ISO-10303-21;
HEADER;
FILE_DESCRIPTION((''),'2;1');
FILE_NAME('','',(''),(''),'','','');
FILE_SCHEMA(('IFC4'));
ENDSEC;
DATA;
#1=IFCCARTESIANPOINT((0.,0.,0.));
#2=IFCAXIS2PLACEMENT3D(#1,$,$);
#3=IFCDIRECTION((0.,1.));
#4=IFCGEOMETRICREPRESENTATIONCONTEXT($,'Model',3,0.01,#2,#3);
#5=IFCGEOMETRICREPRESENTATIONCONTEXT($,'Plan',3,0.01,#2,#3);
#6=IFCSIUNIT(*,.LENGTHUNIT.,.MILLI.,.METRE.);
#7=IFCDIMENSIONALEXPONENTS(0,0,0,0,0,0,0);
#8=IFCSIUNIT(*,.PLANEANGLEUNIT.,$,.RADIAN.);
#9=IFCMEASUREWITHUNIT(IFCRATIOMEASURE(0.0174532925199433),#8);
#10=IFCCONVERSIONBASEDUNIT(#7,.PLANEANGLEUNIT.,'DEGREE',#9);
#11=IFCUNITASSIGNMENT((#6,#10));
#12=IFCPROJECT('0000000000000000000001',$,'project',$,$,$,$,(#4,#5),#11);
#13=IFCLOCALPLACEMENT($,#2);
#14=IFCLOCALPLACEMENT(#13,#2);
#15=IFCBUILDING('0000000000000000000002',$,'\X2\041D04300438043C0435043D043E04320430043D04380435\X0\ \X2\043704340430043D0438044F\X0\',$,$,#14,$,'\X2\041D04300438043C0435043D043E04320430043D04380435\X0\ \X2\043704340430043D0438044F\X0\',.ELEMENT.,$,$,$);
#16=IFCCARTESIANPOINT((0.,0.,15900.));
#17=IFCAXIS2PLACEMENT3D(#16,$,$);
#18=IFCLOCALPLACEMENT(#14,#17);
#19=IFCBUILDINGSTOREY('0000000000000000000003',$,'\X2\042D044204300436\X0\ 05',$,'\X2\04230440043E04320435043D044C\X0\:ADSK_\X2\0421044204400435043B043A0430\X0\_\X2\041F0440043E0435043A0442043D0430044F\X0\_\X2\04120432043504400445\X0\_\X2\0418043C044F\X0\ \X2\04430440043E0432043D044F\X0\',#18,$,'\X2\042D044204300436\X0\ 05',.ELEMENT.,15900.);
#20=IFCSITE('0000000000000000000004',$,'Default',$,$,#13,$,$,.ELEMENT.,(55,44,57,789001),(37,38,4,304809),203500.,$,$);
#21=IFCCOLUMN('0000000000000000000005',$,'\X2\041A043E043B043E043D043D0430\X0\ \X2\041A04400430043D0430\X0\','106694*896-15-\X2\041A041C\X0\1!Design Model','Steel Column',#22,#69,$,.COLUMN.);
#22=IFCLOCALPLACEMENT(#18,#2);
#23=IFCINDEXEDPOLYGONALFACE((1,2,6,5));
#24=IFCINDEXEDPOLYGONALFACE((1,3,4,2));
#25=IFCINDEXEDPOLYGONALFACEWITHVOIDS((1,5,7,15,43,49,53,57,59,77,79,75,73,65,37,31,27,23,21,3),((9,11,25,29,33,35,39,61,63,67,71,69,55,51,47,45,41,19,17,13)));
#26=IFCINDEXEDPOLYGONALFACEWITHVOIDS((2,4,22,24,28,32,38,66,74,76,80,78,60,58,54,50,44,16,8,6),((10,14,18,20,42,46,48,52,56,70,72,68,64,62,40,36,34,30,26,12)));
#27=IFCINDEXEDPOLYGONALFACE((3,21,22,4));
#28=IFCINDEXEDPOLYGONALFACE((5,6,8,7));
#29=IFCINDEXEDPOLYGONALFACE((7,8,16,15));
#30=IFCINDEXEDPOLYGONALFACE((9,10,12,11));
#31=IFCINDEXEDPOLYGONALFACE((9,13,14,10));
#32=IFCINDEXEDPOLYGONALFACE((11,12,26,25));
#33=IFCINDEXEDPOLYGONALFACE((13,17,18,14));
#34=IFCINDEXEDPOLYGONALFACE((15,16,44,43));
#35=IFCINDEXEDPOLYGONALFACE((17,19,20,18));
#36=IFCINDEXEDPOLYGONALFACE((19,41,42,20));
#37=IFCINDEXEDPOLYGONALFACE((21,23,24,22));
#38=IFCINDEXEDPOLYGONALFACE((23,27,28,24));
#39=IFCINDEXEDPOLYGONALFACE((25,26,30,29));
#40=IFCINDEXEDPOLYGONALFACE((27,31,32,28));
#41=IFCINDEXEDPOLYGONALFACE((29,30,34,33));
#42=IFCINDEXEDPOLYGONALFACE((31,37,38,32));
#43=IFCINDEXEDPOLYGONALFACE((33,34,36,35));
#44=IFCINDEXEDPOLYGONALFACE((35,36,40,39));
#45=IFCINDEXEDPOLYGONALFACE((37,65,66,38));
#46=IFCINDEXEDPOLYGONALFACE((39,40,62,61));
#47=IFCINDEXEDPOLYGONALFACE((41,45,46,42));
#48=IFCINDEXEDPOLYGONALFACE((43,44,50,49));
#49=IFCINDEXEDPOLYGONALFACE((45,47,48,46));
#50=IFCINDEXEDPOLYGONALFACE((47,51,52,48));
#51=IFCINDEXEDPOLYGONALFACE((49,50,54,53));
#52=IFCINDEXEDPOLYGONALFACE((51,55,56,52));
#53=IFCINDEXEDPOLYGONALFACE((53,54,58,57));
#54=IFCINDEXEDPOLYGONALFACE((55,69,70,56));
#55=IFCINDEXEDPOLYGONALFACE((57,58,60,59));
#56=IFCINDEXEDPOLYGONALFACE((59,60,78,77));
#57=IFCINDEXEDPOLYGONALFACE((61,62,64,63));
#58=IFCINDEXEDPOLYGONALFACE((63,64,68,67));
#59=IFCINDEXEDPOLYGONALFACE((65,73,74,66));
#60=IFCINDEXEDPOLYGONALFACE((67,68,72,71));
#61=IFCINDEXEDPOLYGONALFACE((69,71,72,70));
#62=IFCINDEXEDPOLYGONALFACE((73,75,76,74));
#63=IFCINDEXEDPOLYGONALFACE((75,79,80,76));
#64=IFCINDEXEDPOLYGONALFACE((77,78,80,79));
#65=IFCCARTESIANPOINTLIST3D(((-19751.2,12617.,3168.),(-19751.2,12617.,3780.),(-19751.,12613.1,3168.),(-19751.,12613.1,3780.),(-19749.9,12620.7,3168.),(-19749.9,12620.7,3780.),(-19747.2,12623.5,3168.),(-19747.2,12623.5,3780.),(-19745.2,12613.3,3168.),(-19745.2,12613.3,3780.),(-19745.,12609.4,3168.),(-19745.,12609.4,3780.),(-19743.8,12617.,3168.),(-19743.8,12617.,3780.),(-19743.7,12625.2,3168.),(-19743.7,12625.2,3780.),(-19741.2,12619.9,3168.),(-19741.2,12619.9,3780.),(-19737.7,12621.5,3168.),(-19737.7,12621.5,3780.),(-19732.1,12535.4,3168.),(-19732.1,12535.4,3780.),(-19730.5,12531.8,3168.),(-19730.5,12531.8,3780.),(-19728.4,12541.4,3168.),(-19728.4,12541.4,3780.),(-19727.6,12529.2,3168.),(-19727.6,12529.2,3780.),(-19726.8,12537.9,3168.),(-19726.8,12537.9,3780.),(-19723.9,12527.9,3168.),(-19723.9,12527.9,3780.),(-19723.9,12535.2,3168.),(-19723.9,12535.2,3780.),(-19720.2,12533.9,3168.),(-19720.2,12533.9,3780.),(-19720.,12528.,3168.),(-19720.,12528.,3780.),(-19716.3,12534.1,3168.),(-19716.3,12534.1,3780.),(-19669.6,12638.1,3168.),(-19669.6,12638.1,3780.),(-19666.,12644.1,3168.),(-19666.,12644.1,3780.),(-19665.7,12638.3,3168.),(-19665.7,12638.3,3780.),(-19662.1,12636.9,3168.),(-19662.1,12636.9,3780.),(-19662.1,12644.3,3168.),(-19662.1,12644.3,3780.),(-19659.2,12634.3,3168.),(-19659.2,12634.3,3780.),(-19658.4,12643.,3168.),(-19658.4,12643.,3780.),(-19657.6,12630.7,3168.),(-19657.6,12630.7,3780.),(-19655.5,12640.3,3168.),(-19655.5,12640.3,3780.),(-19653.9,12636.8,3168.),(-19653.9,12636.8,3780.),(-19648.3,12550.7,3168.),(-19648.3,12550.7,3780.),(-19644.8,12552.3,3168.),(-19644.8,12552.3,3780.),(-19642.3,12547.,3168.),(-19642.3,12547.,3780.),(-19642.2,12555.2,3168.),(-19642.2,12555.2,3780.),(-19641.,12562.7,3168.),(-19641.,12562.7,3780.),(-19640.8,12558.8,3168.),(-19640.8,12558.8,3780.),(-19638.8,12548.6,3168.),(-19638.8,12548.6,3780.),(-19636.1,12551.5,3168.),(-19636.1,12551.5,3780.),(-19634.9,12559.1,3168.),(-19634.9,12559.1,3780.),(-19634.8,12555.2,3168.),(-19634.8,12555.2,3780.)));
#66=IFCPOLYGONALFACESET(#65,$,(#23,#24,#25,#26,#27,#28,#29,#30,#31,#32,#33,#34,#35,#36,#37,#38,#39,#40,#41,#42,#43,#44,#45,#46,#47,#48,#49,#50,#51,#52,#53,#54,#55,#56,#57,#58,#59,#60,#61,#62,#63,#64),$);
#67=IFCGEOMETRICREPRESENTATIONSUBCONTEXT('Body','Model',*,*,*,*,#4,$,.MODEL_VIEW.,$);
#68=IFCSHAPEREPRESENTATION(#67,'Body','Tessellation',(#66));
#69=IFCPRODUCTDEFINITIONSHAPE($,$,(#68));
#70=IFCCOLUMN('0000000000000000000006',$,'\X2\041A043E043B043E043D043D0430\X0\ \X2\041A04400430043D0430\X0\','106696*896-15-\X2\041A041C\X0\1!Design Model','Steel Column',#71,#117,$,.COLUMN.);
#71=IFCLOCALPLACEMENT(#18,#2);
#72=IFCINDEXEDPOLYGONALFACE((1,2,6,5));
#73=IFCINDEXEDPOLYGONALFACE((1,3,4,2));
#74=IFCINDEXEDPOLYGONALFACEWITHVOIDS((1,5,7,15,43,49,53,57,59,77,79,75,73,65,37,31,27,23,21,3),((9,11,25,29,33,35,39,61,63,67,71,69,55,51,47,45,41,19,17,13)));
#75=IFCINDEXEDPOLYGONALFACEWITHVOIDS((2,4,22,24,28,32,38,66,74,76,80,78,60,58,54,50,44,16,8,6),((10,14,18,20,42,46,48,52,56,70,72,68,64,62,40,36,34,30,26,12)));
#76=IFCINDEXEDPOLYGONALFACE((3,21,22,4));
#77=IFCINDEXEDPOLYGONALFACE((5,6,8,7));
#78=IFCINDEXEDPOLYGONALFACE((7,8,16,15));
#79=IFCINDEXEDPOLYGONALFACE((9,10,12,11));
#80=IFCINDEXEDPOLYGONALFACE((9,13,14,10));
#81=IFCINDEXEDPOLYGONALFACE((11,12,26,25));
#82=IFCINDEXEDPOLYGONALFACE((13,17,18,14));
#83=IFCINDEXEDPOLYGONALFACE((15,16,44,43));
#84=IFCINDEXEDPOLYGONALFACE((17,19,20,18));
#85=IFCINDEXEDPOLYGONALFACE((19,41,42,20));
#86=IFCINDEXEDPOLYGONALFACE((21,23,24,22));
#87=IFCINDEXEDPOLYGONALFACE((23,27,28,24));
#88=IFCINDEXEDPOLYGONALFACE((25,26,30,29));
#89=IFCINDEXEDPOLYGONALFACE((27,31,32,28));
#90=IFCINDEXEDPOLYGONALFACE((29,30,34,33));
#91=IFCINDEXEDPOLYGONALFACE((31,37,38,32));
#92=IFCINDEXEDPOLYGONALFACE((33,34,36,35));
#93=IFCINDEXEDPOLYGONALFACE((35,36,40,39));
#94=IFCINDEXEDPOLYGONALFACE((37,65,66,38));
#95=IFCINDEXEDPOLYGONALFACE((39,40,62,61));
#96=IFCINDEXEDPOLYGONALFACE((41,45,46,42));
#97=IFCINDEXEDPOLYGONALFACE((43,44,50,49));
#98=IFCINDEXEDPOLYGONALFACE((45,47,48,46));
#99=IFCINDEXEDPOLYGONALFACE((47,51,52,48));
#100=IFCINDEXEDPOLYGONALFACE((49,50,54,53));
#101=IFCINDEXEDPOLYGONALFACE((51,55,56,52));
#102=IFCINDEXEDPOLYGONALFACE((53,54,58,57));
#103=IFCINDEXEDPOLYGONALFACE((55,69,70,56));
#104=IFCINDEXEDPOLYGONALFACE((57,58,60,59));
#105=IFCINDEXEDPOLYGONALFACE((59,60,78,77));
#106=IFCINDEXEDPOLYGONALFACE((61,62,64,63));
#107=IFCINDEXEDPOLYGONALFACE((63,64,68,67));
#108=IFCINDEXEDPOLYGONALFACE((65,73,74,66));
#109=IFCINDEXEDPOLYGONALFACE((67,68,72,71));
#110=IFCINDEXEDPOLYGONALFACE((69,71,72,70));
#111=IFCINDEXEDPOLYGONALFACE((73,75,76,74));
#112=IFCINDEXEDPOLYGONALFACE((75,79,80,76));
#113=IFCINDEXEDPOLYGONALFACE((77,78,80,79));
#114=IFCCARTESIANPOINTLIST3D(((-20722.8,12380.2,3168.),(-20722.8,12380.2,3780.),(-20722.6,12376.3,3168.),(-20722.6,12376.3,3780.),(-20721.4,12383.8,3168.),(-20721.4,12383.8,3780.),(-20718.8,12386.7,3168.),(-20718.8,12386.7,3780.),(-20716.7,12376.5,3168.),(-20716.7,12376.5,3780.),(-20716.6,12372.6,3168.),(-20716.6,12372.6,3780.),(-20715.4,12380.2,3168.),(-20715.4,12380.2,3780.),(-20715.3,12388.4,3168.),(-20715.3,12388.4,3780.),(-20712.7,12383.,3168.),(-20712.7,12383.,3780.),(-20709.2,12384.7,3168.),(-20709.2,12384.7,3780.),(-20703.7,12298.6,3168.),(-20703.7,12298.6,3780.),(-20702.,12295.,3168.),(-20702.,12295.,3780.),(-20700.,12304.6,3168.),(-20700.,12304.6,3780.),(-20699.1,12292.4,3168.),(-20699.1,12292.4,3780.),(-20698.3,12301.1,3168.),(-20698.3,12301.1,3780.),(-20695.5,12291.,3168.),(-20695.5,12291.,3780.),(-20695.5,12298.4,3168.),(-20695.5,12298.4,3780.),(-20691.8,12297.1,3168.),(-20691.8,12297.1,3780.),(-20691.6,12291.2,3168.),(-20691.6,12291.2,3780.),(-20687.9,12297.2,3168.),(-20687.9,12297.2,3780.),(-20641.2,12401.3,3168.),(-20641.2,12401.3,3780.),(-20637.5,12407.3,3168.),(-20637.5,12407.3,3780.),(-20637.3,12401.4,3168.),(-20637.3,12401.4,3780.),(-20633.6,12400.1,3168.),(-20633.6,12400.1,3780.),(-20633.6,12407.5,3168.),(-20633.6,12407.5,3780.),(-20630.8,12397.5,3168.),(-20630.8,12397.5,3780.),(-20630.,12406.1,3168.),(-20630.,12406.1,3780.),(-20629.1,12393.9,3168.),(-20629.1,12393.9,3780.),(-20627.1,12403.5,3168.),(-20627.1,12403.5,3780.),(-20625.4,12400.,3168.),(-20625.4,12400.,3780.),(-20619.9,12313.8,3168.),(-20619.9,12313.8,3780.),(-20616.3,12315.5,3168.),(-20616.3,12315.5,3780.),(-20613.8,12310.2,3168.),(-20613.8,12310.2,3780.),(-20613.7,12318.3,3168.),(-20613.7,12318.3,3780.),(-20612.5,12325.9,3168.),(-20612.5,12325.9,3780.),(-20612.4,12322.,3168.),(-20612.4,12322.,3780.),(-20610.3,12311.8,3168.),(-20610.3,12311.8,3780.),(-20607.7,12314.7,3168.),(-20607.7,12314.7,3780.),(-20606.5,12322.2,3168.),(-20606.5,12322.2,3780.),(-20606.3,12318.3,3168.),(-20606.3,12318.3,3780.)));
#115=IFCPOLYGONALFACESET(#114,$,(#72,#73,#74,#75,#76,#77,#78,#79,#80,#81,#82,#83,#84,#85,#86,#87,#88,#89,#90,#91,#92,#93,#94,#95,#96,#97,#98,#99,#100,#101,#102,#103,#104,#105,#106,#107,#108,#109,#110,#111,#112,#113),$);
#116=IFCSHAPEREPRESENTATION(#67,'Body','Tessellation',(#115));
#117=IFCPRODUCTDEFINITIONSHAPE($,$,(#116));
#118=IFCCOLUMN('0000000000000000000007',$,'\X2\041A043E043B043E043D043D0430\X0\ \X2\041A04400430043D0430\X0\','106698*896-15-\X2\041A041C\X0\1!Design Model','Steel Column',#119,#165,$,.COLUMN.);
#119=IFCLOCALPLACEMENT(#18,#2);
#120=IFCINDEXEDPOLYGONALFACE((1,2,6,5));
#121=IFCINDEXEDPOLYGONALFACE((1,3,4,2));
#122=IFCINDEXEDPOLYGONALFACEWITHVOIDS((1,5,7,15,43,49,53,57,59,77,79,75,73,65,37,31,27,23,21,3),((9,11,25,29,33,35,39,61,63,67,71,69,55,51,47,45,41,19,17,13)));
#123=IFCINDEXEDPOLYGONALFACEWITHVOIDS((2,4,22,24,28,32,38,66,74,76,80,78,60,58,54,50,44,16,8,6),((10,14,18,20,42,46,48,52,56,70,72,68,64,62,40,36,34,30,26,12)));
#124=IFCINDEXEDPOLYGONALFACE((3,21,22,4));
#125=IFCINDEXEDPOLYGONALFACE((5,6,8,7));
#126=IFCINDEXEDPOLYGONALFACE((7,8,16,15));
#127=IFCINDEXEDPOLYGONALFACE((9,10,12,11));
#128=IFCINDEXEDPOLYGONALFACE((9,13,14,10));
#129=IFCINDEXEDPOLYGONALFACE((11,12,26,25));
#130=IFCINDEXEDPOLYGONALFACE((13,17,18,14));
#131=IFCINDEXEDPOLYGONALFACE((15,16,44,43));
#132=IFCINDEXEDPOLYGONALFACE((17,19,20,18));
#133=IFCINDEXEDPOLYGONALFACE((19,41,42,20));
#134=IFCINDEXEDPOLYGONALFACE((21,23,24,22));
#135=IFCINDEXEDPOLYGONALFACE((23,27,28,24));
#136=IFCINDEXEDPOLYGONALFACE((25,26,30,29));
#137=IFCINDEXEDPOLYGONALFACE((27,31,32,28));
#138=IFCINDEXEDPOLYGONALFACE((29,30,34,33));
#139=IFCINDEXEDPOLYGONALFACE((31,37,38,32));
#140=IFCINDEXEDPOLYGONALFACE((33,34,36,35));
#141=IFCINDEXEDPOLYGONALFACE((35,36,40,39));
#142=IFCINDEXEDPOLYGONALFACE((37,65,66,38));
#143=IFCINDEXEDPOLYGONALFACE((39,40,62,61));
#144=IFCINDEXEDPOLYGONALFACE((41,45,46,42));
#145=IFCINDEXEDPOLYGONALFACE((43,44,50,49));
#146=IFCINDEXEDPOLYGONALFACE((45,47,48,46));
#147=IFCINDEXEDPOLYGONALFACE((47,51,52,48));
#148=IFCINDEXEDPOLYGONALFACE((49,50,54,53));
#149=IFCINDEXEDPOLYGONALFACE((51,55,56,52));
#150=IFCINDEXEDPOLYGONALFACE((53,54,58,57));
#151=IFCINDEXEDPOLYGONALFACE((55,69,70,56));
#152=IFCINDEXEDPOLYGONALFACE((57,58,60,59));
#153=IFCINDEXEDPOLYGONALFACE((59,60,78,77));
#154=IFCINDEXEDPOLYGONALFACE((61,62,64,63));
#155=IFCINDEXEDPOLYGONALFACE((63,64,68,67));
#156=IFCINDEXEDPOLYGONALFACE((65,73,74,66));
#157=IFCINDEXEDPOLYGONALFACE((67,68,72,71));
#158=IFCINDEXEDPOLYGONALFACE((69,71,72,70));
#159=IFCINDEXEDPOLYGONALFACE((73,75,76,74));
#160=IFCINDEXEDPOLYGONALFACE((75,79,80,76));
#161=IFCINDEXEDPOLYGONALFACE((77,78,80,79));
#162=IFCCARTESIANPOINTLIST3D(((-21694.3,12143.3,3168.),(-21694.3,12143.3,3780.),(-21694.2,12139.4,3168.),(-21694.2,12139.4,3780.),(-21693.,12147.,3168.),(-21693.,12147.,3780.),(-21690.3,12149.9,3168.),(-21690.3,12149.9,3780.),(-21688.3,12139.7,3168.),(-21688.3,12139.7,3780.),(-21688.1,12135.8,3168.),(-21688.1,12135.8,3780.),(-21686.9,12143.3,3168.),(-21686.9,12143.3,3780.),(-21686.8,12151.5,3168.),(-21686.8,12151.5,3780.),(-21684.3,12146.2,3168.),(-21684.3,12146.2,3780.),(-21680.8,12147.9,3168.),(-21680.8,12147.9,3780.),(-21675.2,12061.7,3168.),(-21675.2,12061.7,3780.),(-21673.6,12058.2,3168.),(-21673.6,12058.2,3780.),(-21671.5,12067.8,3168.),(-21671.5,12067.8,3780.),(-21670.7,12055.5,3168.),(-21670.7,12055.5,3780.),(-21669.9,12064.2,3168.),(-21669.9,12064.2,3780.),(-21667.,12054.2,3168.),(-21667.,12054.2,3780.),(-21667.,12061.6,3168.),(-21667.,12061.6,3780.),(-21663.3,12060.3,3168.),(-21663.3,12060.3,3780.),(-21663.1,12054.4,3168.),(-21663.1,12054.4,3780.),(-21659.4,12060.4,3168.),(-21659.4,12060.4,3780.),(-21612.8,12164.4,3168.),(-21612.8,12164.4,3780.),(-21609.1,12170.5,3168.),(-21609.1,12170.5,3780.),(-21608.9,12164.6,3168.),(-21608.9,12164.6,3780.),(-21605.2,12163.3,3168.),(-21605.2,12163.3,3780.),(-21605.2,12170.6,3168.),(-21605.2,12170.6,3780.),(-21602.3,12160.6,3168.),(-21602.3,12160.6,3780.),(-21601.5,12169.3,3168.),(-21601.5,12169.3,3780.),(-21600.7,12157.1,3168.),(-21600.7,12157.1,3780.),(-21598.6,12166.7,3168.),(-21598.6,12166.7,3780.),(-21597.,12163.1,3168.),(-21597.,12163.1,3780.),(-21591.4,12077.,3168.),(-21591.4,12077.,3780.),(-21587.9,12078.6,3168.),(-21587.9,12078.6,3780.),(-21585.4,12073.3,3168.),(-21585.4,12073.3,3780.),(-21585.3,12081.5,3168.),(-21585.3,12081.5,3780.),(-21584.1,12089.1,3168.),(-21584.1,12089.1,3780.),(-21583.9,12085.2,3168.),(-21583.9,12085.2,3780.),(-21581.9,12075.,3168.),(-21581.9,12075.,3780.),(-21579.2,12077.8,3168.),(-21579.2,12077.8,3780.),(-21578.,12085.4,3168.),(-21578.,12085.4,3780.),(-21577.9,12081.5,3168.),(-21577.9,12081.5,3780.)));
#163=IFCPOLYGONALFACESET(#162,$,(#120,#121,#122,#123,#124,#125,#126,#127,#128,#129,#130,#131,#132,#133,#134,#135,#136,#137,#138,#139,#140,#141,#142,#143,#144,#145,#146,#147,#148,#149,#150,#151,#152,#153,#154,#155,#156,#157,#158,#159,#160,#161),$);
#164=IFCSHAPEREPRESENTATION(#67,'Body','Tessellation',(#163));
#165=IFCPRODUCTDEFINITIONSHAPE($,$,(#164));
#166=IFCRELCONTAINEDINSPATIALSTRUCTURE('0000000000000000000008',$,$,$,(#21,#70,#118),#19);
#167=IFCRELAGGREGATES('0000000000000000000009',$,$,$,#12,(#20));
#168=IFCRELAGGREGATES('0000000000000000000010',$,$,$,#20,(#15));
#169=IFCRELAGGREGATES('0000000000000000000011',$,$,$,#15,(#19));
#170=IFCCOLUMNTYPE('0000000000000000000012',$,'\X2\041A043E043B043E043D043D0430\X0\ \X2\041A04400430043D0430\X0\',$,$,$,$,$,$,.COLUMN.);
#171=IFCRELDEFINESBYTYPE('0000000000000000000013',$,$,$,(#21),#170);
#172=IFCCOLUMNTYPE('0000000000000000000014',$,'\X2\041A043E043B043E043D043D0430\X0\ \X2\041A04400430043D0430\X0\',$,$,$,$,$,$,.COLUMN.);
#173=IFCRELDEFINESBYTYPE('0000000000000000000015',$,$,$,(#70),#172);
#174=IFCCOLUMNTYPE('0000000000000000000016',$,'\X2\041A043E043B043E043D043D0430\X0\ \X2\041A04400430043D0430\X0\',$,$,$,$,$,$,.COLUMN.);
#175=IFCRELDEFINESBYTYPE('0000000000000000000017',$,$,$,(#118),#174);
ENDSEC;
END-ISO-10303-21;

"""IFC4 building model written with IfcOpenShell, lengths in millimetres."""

from ifc_helpers import new_model, entity, si_unit, converted_unit, direction, frame, origin, place, context, subcontext, project, spatial, indexed_curve, outline, extrude, type_object, element, save


model = new_model("IFC4")

# Units and contexts
model_context = context("Model", 3, precision=0.01, world=origin(), true_north=direction((0.0, 1.0)))
plan_context = context("Plan", 3, precision=0.01, world=origin(), true_north=direction((0.0, 1.0)))
body_context = subcontext(model_context, "Body", "Model", "MODEL_VIEW")
ifc_project = project(units=[si_unit("LENGTHUNIT", "METRE", prefix="MILLI"), converted_unit("PLANEANGLEUNIT", "DEGREE", entity("IfcRatioMeasure", 0.0174532925199433), si_unit("PLANEANGLEUNIT", "RADIAN"), dimensions=[0, 0, 0, 0, 0, 0, 0])], contexts=[model_context, plan_context])

# Site, building, storey
site_placement = place(None, origin())
site = spatial("IfcSite", under=ifc_project, at=site_placement, Name="Default", CompositionType="ELEMENT", RefLatitude=(55, 44, 57, 789001), RefLongitude=(37, 38, 4, 304809), RefElevation=203500.0)
building_placement = place(site_placement, origin())
building = spatial("IfcBuilding", under=site, at=building_placement, Name="Наименование здания", LongName="Наименование здания", CompositionType="ELEMENT")
storey_placement = place(building_placement, frame((0.0, 0.0, 15900.0)))
storey = spatial("IfcBuildingStorey", under=building, at=storey_placement, Name="Этаж 05", ObjectType="Уровень:ADSK_Стрелка_Проектная_Вверх_Имя уровня", LongName="Этаж 05", CompositionType="ELEMENT", Elevation=15900.0)

# Columns
column_type_1 = type_object("IfcColumnType", Name="Колонна Крана", PredefinedType="COLUMN")
column_1_placement = place(storey_placement, origin())
element("IfcColumn", 1, at=column_1_placement, inside=storey, type_object=column_type_1, Name="Колонна Крана", Description="106694*896-15-КМ1!Design Model", ObjectType="Steel Column", PredefinedType="COLUMN", context=body_context, shape_type="SweptSolid", body=[
    extrude(outline(indexed_curve([(29.5, -56.8), (33.4, -56.8), (37.0, -55.3), (39.7, -52.6), (41.2, -49.0), (56.8, 29.5), (56.8, 33.4), (55.3, 37.0), (52.6, 39.7), (49.0, 41.2), (-29.5, 56.8), (-33.4, 56.8), (-37.0, 55.3), (-39.7, 52.6), (-41.2, 49.0), (-56.8, -29.5), (-56.8, -33.4), (-55.3, -37.0), (-52.6, -39.7), (-49.0, -41.2), (29.5, -56.8)], self_intersect=False), holes=[indexed_curve([(-43.1, -37.3), (-46.7, -35.8), (-49.5, -33.1), (-51.0, -29.5), (-51.0, -25.5), (-37.3, 43.1), (-35.8, 46.7), (-33.1, 49.5), (-29.5, 51.0), (-25.5, 51.0), (43.1, 37.3), (46.7, 35.8), (49.5, 33.1), (51.0, 29.5), (51.0, 25.5), (37.3, -43.1), (35.8, -46.7), (33.1, -49.5), (29.5, -51.0), (25.5, -51.0), (-43.1, -37.3)], self_intersect=False)]), frame((-19693.0, 12586.1, 3168.0), z_axis=(0.0, 0.0, 1.0), x_axis=(-0.906681, -0.421816, 0.0)), (0.0, 0.0, 1.0), 612.0),
])
column_type_2 = type_object("IfcColumnType", Name="Колонна Крана", PredefinedType="COLUMN")
column_2_placement = place(storey_placement, origin())
element("IfcColumn", 2, at=column_2_placement, inside=storey, type_object=column_type_2, Name="Колонна Крана", Description="106696*896-15-КМ1!Design Model", ObjectType="Steel Column", PredefinedType="COLUMN", context=body_context, shape_type="SweptSolid", body=[
    extrude(outline(indexed_curve([(29.5, -56.8), (33.4, -56.8), (37.0, -55.3), (39.7, -52.6), (41.2, -49.0), (56.8, 29.5), (56.8, 33.4), (55.3, 37.0), (52.6, 39.7), (49.0, 41.2), (-29.5, 56.8), (-33.4, 56.8), (-37.0, 55.3), (-39.7, 52.6), (-41.2, 49.0), (-56.8, -29.5), (-56.8, -33.4), (-55.3, -37.0), (-52.6, -39.7), (-49.0, -41.2), (29.5, -56.8)], self_intersect=False), holes=[indexed_curve([(-43.1, -37.3), (-46.7, -35.8), (-49.5, -33.1), (-51.0, -29.5), (-51.0, -25.5), (-37.3, 43.1), (-35.8, 46.7), (-33.1, 49.5), (-29.5, 51.0), (-25.5, 51.0), (43.1, 37.3), (46.7, 35.8), (49.5, 33.1), (51.0, 29.5), (51.0, 25.5), (37.3, -43.1), (35.8, -46.7), (33.1, -49.5), (29.5, -51.0), (25.5, -51.0), (-43.1, -37.3)], self_intersect=False)]), frame((-20664.5, 12349.3, 3168.0), z_axis=(0.0, 0.0, 1.0), x_axis=(-0.906681, -0.421816, 0.0)), (0.0, 0.0, 1.0), 612.0),
])
column_type_3 = type_object("IfcColumnType", Name="Колонна Крана", PredefinedType="COLUMN")
column_3_placement = place(storey_placement, origin())
element("IfcColumn", 3, at=column_3_placement, inside=storey, type_object=column_type_3, Name="Колонна Крана", Description="106698*896-15-КМ1!Design Model", ObjectType="Steel Column", PredefinedType="COLUMN", context=body_context, shape_type="SweptSolid", body=[
    extrude(outline(indexed_curve([(29.5, -56.8), (33.4, -56.8), (37.0, -55.3), (39.7, -52.6), (41.2, -49.0), (56.8, 29.5), (56.8, 33.4), (55.3, 37.0), (52.6, 39.7), (49.0, 41.2), (-29.5, 56.8), (-33.4, 56.8), (-37.0, 55.3), (-39.7, 52.6), (-41.2, 49.0), (-56.8, -29.5), (-56.8, -33.4), (-55.3, -37.0), (-52.6, -39.7), (-49.0, -41.2), (29.5, -56.8)], self_intersect=False), holes=[indexed_curve([(-43.1, -37.3), (-46.7, -35.8), (-49.5, -33.1), (-51.0, -29.5), (-51.0, -25.5), (-37.3, 43.1), (-35.8, 46.7), (-33.1, 49.5), (-29.5, 51.0), (-25.5, 51.0), (43.1, 37.3), (46.7, 35.8), (49.5, 33.1), (51.0, 29.5), (51.0, 25.5), (37.3, -43.1), (35.8, -46.7), (33.1, -49.5), (29.5, -51.0), (25.5, -51.0), (-43.1, -37.3)], self_intersect=False)]), frame((-21636.1, 12112.4, 3168.0), z_axis=(0.0, 0.0, 1.0), x_axis=(-0.906681, -0.421816, 0.0)), (0.0, 0.0, 1.0), 612.0),
])

save(model, "model.ifc")
